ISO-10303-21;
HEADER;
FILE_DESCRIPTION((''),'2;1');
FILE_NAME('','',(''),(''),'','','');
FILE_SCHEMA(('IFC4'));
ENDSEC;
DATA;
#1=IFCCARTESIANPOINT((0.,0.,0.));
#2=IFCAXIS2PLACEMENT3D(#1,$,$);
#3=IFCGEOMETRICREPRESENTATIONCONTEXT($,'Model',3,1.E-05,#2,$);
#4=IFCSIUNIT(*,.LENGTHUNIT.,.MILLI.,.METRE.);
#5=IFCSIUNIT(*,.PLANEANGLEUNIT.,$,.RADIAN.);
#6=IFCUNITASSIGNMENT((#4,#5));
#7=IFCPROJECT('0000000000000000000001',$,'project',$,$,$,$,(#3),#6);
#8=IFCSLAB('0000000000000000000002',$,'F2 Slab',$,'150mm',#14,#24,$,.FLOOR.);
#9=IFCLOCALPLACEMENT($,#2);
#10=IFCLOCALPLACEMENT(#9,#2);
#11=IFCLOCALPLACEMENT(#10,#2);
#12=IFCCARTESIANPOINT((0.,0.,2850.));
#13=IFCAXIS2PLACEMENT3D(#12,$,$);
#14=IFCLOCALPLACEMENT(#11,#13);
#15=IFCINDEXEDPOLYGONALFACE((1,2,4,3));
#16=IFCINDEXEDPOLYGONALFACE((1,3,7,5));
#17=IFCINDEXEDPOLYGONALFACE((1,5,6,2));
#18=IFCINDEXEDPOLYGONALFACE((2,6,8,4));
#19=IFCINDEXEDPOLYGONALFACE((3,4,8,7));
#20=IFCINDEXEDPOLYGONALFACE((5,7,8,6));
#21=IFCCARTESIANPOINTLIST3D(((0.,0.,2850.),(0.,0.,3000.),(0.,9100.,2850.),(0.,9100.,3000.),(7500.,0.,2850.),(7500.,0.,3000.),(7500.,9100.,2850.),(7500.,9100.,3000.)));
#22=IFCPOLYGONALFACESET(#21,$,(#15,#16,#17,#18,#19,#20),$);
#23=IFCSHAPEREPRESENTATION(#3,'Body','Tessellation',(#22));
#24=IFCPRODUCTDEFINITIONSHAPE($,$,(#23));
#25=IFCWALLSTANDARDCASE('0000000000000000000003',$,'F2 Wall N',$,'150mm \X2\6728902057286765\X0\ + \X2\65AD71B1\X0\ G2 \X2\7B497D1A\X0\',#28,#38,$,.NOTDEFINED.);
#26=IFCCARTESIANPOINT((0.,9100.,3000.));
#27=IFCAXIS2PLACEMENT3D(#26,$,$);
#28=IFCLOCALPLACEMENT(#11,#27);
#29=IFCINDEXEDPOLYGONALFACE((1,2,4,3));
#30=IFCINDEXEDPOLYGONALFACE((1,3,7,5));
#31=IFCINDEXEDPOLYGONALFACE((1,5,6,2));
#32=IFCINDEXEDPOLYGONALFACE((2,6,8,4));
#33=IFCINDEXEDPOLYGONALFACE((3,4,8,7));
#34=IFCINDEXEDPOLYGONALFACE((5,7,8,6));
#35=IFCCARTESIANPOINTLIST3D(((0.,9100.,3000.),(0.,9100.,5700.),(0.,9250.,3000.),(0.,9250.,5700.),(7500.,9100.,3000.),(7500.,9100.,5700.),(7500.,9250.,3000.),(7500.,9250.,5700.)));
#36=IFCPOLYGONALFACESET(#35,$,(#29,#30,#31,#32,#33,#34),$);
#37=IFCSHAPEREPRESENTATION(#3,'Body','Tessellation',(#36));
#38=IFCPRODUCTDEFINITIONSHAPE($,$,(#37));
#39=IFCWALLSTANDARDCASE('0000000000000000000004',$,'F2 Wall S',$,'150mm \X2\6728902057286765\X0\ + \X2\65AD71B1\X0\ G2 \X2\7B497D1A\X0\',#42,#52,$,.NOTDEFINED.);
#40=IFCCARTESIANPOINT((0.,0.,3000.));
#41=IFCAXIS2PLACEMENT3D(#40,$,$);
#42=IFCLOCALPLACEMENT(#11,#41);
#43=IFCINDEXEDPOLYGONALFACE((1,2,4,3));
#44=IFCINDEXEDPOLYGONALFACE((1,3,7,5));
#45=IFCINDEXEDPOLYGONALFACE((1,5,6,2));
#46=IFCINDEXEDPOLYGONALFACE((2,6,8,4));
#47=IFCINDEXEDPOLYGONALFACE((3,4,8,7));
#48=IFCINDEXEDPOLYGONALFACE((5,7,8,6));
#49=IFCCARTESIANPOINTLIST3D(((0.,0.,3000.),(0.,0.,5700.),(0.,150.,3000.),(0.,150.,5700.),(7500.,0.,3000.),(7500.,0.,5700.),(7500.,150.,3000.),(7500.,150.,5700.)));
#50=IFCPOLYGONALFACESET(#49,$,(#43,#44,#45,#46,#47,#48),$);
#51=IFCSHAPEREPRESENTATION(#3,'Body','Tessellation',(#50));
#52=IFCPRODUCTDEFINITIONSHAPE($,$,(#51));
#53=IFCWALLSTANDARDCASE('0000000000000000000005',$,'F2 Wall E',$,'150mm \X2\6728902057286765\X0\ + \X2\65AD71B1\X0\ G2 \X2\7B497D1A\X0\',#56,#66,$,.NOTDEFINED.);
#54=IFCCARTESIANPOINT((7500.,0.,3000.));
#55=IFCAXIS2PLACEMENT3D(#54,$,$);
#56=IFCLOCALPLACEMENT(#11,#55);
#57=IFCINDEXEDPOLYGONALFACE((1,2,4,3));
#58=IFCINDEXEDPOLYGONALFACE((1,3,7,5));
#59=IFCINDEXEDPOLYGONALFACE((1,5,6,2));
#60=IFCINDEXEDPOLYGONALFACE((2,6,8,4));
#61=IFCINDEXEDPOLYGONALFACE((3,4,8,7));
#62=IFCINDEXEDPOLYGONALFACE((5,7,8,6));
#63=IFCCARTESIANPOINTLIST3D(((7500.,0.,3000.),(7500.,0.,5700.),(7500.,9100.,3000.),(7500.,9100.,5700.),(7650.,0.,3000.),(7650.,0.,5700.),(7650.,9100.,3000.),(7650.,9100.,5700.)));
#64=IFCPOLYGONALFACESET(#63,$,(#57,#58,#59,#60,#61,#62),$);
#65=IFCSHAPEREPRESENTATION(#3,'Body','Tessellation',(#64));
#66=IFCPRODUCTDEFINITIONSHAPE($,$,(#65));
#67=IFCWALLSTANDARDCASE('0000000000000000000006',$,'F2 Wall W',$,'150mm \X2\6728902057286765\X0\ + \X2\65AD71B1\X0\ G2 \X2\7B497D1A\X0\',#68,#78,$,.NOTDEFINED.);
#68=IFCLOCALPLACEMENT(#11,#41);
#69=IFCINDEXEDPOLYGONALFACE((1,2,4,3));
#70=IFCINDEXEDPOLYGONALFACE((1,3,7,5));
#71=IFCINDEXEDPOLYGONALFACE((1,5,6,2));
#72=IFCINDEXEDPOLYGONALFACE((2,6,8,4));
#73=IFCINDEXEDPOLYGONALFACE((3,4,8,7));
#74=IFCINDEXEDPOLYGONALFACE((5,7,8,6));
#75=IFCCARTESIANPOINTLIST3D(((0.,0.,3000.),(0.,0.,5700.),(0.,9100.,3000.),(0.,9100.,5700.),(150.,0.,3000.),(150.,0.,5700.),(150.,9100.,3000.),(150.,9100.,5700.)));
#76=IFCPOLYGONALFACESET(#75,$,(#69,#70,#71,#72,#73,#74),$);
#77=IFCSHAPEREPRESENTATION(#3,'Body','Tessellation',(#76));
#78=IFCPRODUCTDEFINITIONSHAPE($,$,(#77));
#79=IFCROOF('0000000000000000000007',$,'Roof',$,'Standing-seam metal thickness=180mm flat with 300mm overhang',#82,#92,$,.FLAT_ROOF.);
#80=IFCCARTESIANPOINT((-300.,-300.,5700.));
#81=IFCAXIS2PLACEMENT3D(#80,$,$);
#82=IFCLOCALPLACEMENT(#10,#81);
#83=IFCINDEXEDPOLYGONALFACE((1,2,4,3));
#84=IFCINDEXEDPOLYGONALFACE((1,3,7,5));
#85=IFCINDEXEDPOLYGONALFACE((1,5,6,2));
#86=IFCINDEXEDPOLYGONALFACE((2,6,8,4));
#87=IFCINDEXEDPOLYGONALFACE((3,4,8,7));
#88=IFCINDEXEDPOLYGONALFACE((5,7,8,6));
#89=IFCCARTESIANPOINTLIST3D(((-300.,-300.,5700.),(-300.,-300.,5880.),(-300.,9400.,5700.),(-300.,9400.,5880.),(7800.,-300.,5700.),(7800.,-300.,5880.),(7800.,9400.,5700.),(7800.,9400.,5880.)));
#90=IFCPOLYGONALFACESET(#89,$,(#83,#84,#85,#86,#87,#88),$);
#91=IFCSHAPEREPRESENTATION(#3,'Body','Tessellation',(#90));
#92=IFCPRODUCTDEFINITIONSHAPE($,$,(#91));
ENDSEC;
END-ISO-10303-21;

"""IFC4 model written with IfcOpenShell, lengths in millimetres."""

from ifc_helpers import new_model, si_unit, frame, frame_2d, origin, place, context, project, rectangle, extrude, element, save


model = new_model("IFC4")

# Units and contexts
model_context = context("Model", 3, precision=1e-05, world=origin())
ifc_project = project(units=[si_unit("LENGTHUNIT", "METRE", prefix="MILLI"), si_unit("PLANEANGLEUNIT", "RADIAN")], contexts=[model_context])

# Slab
placement_1 = place(None, origin())
placement_2 = place(placement_1, origin())
placement_3 = place(placement_2, origin())
slab_placement = place(placement_3, frame((0.0, 0.0, 2850.0)))
element("IfcSlab", 1, at=slab_placement, Name="F2 Slab", ObjectType="150mm", PredefinedType="FLOOR", context=model_context, shape_type="SweptSolid", body=[
    extrude(rectangle(XDim=7500.0, YDim=9100.0, at=frame_2d((3750.0, 4550.0))), frame((0.0, 0.0, 2850.0)), (0.0, 0.0, 1.0), 150.0),
])

# Walls
wall_1_placement = place(placement_3, frame((0.0, 9100.0, 3000.0)))
element("IfcWallStandardCase", 2, at=wall_1_placement, Name="F2 Wall N", ObjectType="150mm 木造在来 + 断熱 G2 等級", PredefinedType="NOTDEFINED", context=model_context, shape_type="SweptSolid", body=[
    extrude(rectangle(XDim=7500.0, YDim=150.0, at=frame_2d((3750.0, 75.0))), frame((0.0, 9100.0, 3000.0)), (0.0, 0.0, 1.0), 2700.0),
])
wall_2_placement = place(placement_3, frame((0.0, 0.0, 3000.0)))
element("IfcWallStandardCase", 3, at=wall_2_placement, Name="F2 Wall S", ObjectType="150mm 木造在来 + 断熱 G2 等級", PredefinedType="NOTDEFINED", context=model_context, shape_type="SweptSolid", body=[
    extrude(rectangle(XDim=7500.0, YDim=150.0, at=frame_2d((3750.0, 75.0))), frame((0.0, 0.0, 3000.0)), (0.0, 0.0, 1.0), 2700.0),
])
wall_3_placement = place(placement_3, frame((7500.0, 0.0, 3000.0)))
element("IfcWallStandardCase", 4, at=wall_3_placement, Name="F2 Wall E", ObjectType="150mm 木造在来 + 断熱 G2 等級", PredefinedType="NOTDEFINED", context=model_context, shape_type="SweptSolid", body=[
    extrude(rectangle(XDim=150.0, YDim=9100.0, at=frame_2d((75.0, 4550.0))), frame((7500.0, 0.0, 3000.0)), (0.0, 0.0, 1.0), 2700.0),
])
wall_4_placement = place(placement_3, frame((0.0, 0.0, 3000.0)))
element("IfcWallStandardCase", 5, at=wall_4_placement, Name="F2 Wall W", ObjectType="150mm 木造在来 + 断熱 G2 等級", PredefinedType="NOTDEFINED", context=model_context, shape_type="SweptSolid", body=[
    extrude(rectangle(XDim=150.0, YDim=9100.0, at=frame_2d((75.0, 4550.0))), frame((0.0, 0.0, 3000.0)), (0.0, 0.0, 1.0), 2700.0),
])

# Roof
roof_placement = place(placement_2, frame((-300.0, -300.0, 5700.0)))
element("IfcRoof", 6, at=roof_placement, Name="Roof", ObjectType="Standing-seam metal thickness=180mm flat with 300mm overhang", PredefinedType="FLAT_ROOF", context=model_context, shape_type="SweptSolid", body=[
    extrude(rectangle(XDim=8100.0, YDim=9700.0, at=frame_2d((4050.0, 4850.0))), frame((-300.0, -300.0, 5700.0)), (0.0, 0.0, 1.0), 180.0),
])

save(model, "model.ifc")
